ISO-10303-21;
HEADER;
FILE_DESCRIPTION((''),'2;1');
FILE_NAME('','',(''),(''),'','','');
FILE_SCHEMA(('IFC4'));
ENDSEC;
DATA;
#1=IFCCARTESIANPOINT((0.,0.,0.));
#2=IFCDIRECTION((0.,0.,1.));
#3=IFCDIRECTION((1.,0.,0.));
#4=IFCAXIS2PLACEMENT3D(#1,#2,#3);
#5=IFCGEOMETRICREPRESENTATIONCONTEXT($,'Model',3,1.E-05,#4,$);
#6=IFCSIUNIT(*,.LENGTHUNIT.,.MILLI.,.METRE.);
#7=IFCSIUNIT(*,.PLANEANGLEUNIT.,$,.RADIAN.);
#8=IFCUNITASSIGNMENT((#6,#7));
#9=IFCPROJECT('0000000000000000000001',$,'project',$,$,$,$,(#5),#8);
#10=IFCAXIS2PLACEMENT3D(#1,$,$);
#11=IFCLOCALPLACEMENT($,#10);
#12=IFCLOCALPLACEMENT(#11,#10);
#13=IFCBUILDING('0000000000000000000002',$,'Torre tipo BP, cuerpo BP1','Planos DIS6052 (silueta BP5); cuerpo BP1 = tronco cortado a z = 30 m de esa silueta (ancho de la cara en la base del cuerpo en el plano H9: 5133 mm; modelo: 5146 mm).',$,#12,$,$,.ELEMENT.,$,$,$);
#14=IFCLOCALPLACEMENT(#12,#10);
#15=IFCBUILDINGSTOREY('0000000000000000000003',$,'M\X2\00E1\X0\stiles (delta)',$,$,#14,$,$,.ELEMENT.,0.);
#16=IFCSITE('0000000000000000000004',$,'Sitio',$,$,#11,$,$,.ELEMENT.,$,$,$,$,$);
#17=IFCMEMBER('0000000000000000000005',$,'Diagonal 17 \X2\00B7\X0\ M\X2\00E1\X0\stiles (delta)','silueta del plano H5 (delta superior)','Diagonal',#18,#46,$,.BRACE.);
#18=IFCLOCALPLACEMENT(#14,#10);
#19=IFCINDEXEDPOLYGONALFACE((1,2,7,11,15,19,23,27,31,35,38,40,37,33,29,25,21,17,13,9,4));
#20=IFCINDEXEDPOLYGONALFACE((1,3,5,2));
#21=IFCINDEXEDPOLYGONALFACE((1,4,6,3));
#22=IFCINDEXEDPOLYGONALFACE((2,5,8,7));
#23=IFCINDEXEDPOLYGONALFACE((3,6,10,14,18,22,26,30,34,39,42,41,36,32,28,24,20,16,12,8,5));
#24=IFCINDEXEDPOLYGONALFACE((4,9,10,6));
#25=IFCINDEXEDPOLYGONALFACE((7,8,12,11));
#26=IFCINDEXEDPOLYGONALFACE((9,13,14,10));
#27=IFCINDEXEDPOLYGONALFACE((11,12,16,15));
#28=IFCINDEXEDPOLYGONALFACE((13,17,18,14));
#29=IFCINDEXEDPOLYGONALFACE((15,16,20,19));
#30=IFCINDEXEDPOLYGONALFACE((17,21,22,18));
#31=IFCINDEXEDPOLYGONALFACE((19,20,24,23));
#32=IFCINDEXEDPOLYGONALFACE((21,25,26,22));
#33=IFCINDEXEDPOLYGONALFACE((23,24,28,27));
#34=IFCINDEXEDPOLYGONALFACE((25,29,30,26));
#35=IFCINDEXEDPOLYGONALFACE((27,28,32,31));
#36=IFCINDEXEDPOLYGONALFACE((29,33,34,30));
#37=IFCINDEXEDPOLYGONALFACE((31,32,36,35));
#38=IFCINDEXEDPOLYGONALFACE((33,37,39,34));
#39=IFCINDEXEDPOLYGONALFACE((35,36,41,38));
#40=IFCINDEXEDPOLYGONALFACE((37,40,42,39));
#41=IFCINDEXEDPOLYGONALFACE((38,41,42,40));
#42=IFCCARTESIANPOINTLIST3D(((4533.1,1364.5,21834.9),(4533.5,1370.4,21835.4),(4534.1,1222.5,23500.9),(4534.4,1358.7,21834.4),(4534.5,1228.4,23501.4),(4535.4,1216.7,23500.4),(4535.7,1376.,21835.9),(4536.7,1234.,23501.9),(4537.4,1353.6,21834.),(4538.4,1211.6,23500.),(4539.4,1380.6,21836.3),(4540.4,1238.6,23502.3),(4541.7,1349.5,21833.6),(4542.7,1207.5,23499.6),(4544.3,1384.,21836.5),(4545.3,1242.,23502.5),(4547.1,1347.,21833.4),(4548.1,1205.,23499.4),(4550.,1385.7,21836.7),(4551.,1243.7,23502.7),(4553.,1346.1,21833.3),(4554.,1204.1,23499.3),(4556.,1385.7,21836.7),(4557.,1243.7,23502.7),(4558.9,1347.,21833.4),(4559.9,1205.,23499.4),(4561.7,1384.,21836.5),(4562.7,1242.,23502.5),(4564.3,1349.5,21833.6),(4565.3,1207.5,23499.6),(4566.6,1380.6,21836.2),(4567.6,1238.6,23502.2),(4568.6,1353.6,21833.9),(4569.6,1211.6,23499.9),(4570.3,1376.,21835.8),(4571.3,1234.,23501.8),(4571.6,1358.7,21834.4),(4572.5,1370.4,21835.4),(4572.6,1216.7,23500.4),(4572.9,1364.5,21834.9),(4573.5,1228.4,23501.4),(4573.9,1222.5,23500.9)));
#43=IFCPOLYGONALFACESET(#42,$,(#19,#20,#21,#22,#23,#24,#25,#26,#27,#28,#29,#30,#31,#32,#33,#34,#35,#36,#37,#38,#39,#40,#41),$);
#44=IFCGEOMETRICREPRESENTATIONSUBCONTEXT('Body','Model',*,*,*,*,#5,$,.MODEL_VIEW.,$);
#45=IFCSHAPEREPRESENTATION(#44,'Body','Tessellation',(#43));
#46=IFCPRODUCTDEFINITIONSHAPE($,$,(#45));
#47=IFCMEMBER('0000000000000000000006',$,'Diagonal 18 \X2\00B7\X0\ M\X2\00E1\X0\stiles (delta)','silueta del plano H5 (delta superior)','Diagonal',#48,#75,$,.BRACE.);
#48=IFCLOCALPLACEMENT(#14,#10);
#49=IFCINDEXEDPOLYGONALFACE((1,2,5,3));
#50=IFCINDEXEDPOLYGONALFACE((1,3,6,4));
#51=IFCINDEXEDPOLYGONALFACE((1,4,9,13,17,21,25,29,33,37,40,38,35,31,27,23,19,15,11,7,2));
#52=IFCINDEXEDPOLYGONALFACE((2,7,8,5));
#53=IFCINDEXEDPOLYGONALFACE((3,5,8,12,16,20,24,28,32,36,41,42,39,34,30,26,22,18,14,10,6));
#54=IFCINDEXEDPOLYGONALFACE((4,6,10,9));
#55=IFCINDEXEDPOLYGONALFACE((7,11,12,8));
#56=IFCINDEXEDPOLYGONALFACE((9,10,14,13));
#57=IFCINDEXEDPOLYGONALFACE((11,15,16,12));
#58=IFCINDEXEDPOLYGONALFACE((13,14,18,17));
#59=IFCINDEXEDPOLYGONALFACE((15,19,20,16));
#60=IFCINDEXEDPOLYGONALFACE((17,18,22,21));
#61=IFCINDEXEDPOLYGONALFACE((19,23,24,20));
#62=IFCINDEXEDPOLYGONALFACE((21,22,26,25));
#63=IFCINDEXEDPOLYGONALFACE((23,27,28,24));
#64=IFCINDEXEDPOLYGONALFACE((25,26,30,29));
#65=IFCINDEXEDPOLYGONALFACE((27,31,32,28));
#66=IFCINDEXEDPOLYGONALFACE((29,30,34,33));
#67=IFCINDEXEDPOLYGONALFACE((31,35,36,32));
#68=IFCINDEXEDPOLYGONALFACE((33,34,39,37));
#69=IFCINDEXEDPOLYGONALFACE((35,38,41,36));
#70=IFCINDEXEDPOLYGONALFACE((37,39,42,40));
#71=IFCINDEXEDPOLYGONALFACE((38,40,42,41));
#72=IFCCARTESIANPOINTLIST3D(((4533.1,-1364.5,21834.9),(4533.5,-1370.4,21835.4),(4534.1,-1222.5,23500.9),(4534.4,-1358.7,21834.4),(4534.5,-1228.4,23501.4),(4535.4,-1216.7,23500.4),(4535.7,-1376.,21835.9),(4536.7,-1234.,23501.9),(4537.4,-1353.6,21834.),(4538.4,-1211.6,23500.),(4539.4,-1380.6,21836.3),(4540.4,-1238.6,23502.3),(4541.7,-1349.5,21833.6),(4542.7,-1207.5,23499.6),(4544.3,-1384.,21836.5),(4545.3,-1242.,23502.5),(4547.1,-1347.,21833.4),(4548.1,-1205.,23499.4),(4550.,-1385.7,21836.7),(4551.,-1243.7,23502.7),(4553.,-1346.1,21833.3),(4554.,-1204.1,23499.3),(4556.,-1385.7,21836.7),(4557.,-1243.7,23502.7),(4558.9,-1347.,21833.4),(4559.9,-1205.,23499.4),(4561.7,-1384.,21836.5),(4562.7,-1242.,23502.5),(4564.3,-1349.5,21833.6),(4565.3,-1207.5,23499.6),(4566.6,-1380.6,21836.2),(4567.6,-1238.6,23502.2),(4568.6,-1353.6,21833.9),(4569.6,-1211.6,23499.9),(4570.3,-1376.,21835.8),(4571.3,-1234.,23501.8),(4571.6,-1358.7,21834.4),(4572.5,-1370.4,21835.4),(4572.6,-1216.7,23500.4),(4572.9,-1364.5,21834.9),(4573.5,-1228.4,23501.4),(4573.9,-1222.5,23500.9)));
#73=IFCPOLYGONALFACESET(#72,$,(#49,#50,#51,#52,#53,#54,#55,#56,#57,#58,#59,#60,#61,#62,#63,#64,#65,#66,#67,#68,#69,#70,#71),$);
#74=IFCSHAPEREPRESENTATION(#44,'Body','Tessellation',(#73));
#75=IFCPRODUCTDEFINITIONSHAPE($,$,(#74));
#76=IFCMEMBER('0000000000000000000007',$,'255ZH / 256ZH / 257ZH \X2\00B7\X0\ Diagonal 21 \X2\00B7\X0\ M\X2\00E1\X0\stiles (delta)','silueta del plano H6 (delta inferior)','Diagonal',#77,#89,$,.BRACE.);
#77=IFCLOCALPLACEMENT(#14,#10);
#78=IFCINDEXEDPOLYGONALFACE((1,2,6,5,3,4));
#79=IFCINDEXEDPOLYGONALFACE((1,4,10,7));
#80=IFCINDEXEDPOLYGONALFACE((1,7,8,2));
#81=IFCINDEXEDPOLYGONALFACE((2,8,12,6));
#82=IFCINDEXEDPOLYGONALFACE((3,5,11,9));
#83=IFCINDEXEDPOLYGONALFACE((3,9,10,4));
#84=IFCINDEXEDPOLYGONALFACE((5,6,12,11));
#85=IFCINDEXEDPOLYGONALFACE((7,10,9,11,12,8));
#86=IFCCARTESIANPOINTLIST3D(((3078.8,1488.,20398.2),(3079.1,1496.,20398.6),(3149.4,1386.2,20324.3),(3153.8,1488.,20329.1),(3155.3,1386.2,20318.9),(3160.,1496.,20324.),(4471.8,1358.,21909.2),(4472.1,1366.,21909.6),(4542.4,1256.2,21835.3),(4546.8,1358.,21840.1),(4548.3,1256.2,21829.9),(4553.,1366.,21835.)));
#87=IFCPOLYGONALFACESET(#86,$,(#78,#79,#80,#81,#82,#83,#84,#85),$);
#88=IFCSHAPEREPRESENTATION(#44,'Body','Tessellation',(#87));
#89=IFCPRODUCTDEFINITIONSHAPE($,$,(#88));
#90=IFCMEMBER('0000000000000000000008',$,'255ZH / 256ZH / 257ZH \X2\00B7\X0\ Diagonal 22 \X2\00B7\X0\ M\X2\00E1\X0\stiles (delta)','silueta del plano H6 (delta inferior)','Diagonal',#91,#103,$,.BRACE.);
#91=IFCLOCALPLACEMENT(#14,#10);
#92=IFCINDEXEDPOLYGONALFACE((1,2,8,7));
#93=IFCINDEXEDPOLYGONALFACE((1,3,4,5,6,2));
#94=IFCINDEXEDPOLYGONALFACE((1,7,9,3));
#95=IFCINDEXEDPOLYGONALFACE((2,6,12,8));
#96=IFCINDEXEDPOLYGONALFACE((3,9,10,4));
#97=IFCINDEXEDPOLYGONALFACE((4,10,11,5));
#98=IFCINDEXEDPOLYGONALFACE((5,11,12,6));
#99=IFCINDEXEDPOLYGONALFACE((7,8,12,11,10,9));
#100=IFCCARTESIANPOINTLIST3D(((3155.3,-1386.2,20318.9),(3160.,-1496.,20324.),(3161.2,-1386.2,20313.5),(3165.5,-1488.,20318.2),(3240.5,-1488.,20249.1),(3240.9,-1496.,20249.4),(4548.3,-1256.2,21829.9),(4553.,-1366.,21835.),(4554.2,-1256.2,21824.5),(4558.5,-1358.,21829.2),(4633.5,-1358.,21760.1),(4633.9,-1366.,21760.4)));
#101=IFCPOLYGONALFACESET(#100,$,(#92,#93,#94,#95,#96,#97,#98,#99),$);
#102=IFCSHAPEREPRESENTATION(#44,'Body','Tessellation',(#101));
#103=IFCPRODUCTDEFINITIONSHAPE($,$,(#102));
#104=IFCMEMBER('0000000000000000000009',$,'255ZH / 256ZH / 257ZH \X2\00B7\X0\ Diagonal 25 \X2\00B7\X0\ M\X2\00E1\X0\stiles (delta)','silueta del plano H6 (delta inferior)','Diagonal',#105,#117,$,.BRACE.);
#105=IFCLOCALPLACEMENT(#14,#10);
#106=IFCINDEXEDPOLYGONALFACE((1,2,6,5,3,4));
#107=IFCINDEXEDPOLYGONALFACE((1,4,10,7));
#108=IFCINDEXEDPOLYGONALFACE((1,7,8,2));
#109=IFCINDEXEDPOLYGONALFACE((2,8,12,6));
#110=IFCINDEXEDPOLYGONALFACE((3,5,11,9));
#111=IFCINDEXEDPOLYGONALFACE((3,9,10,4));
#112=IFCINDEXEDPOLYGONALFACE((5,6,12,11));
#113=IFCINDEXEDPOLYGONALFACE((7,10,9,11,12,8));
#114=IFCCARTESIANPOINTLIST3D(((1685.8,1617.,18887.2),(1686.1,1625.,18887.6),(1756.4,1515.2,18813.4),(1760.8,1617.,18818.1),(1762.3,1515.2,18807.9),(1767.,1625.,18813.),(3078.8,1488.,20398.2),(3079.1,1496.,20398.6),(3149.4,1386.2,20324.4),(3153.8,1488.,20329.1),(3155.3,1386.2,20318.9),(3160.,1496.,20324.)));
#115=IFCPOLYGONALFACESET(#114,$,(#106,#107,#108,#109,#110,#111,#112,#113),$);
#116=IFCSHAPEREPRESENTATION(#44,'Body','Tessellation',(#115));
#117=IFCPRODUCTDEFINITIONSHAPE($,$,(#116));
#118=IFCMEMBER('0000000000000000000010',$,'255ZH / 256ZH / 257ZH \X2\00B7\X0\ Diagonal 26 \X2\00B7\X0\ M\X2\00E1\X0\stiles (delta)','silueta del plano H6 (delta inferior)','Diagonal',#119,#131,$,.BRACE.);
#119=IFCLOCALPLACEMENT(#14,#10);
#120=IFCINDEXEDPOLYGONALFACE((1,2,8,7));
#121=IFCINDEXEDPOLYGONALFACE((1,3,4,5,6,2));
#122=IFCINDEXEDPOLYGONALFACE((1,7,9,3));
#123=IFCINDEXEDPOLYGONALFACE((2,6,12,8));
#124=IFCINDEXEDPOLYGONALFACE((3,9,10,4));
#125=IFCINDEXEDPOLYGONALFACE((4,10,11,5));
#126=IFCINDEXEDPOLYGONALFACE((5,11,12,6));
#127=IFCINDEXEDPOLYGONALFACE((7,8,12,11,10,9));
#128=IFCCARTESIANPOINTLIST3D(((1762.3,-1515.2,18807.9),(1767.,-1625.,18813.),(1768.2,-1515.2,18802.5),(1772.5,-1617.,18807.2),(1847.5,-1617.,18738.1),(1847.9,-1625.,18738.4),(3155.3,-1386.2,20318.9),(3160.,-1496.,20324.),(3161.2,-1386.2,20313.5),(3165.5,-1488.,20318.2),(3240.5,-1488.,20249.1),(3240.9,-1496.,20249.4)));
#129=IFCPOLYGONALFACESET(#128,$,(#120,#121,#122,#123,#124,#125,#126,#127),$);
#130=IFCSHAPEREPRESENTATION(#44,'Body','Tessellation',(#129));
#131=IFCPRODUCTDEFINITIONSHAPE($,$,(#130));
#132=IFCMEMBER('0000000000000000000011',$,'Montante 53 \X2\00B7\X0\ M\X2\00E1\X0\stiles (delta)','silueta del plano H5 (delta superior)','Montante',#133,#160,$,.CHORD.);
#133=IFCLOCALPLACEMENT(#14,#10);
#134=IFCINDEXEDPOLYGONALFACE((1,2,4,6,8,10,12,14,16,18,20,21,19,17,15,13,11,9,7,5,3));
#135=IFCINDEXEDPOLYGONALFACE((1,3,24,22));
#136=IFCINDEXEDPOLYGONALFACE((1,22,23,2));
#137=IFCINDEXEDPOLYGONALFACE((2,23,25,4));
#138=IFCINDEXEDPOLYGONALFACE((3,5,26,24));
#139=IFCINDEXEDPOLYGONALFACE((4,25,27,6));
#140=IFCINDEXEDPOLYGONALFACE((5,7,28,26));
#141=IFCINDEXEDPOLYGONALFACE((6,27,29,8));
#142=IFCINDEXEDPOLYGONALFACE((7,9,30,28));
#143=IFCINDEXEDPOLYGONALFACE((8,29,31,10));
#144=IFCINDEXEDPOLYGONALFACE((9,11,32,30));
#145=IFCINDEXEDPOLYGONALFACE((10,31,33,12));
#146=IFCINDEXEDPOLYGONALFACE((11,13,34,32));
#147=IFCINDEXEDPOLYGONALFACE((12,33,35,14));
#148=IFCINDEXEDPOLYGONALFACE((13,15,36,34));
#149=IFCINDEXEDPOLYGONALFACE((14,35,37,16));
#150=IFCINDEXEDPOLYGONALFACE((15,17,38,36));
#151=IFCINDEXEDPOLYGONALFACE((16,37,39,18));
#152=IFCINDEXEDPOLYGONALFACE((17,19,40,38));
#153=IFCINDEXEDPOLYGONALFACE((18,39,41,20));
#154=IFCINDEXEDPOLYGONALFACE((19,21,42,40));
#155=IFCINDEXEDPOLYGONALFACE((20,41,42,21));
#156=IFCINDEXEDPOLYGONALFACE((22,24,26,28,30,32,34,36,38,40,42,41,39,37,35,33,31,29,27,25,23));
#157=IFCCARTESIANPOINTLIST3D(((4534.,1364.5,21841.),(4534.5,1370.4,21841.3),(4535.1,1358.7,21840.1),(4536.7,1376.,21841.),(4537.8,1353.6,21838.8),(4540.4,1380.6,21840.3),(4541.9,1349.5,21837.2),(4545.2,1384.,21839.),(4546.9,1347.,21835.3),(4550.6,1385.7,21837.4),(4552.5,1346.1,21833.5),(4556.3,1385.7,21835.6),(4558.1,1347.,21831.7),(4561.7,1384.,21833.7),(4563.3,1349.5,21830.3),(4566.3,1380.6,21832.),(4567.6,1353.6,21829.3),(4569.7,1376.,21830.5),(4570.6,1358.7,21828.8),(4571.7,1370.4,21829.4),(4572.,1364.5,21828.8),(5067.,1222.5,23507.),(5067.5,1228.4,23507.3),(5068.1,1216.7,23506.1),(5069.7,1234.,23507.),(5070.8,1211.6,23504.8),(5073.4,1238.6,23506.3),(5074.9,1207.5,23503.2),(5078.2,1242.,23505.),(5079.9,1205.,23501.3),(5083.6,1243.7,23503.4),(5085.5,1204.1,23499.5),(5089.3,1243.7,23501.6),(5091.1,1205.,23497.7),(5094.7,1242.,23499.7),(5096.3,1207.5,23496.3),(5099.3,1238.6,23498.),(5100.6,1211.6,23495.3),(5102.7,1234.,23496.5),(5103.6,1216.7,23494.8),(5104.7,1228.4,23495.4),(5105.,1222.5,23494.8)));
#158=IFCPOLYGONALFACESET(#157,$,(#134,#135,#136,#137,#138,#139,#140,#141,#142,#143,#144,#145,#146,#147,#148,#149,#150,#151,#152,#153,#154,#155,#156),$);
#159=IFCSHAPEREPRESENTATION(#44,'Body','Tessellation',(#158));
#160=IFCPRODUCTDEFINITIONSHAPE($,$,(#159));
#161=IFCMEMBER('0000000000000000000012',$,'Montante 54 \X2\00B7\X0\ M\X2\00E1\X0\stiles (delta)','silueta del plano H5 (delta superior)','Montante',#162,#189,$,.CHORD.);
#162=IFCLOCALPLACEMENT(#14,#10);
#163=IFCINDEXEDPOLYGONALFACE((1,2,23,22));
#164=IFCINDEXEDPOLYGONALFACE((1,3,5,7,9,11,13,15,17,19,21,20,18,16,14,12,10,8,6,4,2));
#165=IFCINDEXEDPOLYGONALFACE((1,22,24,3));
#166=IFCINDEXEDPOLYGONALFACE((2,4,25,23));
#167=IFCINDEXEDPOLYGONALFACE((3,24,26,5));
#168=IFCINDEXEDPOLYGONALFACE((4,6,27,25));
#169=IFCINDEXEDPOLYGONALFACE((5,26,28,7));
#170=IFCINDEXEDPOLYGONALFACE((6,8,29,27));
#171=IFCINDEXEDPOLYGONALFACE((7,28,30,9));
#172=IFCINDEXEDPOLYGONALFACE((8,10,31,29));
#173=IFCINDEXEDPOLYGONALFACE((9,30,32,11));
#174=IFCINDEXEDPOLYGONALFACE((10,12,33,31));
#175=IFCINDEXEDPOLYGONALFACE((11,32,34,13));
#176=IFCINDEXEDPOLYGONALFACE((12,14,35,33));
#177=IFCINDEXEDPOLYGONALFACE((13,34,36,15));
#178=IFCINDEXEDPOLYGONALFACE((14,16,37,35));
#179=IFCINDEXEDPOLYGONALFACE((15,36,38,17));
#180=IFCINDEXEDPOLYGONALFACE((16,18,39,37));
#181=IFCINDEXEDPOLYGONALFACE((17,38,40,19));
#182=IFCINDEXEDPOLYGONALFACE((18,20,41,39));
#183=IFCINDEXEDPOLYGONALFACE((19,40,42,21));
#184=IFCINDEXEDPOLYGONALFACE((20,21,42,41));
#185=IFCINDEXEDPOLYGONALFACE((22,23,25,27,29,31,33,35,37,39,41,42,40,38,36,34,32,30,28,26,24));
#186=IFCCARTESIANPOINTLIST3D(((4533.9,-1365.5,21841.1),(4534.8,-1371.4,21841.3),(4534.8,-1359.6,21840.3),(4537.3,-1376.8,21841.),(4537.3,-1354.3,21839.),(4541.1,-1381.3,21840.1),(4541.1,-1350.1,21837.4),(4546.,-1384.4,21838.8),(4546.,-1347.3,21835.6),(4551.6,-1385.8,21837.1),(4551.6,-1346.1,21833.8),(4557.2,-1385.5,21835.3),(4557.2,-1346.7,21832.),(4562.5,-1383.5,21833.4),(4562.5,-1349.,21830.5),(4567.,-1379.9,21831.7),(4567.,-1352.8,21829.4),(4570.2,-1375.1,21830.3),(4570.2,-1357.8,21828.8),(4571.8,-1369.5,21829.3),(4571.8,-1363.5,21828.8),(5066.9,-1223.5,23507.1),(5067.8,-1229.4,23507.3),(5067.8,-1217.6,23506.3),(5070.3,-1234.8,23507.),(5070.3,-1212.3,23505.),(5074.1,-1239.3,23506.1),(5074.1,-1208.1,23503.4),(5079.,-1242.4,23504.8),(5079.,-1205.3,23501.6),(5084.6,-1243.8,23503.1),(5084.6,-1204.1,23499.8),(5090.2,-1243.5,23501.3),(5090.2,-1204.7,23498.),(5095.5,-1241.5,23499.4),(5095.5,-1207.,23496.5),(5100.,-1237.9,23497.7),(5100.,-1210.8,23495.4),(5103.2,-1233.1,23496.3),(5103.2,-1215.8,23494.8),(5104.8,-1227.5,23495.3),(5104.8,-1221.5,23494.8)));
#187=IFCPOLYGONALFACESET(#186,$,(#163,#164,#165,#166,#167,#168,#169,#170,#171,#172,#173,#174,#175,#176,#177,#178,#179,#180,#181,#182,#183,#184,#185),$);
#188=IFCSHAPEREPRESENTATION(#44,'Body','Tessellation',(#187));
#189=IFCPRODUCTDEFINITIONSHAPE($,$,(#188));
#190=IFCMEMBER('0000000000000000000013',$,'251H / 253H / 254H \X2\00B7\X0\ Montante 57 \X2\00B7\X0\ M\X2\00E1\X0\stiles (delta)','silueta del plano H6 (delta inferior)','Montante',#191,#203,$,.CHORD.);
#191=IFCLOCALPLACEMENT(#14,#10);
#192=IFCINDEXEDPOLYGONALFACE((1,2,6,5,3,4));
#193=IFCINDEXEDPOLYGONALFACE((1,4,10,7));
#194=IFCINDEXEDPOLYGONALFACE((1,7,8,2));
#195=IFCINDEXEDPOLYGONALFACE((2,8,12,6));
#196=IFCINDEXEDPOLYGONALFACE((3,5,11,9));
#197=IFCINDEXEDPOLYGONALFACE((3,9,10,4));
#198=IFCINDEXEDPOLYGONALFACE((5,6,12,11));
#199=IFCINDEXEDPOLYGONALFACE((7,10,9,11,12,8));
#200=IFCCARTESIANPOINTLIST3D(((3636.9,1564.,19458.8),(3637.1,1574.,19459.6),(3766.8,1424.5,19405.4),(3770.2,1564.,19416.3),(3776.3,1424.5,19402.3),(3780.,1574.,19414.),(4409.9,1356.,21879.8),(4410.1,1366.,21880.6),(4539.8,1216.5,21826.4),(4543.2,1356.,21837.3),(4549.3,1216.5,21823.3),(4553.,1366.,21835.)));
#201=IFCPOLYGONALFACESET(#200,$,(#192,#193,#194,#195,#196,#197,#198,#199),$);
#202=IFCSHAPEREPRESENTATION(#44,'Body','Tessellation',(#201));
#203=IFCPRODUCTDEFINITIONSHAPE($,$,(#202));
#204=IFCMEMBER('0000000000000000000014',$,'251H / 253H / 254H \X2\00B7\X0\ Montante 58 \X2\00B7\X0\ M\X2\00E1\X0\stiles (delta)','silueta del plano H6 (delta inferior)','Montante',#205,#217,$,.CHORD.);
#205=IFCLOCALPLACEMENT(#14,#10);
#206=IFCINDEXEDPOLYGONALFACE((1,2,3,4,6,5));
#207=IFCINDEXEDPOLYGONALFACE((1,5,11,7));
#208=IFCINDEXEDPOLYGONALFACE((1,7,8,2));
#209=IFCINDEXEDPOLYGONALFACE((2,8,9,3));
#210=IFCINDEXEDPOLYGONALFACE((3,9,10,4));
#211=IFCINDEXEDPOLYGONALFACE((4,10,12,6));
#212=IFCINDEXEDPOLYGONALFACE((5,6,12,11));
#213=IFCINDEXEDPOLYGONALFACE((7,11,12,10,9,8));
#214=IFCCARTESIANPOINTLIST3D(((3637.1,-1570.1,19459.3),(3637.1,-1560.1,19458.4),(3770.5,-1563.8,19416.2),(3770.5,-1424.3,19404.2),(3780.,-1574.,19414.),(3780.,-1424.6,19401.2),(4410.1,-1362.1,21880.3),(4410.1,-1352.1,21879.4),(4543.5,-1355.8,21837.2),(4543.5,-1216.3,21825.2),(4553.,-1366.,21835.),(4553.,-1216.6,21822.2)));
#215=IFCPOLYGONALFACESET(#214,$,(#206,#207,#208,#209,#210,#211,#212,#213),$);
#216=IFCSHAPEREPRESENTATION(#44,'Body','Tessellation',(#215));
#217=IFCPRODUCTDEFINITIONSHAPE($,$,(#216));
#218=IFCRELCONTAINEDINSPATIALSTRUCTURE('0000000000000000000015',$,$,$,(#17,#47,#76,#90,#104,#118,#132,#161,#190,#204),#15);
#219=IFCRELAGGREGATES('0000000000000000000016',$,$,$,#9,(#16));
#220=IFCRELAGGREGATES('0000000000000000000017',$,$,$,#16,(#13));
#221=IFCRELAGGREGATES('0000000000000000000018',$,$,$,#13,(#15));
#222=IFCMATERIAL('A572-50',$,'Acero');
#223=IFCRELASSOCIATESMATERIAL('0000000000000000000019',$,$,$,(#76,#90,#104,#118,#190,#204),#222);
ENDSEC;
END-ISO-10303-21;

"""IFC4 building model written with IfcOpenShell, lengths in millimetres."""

from ifc_helpers import new_model, si_unit, frame, frame_2d, origin, origin_with_axes, place, context, subcontext, project, spatial, circle, l_section, extrude, material, element, save


model = new_model("IFC4")

# Units and contexts
model_context = context("Model", 3, precision=1e-05, world=origin_with_axes())
body_context = subcontext(model_context, "Body", "Model", "MODEL_VIEW")
ifc_project = project(units=[si_unit("LENGTHUNIT", "METRE", prefix="MILLI"), si_unit("PLANEANGLEUNIT", "RADIAN")], contexts=[model_context])

# Site, building, storey
site_placement = place(None, origin())
site = spatial("IfcSite", under=ifc_project, at=site_placement, Name="Sitio", CompositionType="ELEMENT")
building_placement = place(site_placement, origin())
building = spatial("IfcBuilding", under=site, at=building_placement, Name="Torre tipo BP, cuerpo BP1", Description="Planos DIS6052 (silueta BP5); cuerpo BP1 = tronco cortado a z = 30 m de esa silueta (ancho de la cara en la base del cuerpo en el plano H9: 5133 mm; modelo: 5146 mm).", CompositionType="ELEMENT")
storey_placement = place(building_placement, origin())
storey = spatial("IfcBuildingStorey", under=building, at=storey_placement, Name="Mástiles (delta)", CompositionType="ELEMENT", Elevation=0.0)

# Members
for number, where, z_axis, x_axis, name in (
    (1, (4554.0, 1224.0, 23501.0), (-0.000598, 0.084926, -0.996387), (-0.000051, -0.996387, -0.084926), "Diagonal 17 · Mástiles (delta)"),
    (2, (4554.0, -1224.0, 23501.0), (-0.000598, -0.084926, -0.996387), (-0.000051, 0.996387, -0.084926), "Diagonal 18 · Mástiles (delta)"),
):
    element("IfcMember", number, at=place(storey_placement, frame(where, z_axis=z_axis, x_axis=x_axis)), inside=storey, Name=name, Description="silueta del plano H5 (delta superior)", ObjectType="Diagonal", PredefinedType="BRACE", context=body_context, shape_type="SweptSolid", body=[
        extrude(circle(Radius=20.0), None, (0.0, 0.0, 1.0), 1672.0),
    ])
ifc_material = material(Name="A572-50", Category="Acero")
for number, where, z_axis, x_axis, name in (
    (3, (4553.0, 1366.0, 21835.0), (-0.676463, 0.06313, -0.733766), (-0.042791, -0.998005, -0.046415), "255ZH / 256ZH / 257ZH · Diagonal 21 · Mástiles (delta)"),
    (4, (4553.0, -1366.0, 21835.0), (-0.676463, -0.06313, -0.733766), (-0.042791, 0.998005, -0.046415), "255ZH / 256ZH / 257ZH · Diagonal 22 · Mástiles (delta)"),
):
    element("IfcMember", number, at=place(storey_placement, frame(where, z_axis=z_axis, x_axis=x_axis)), inside=storey, material=ifc_material, Name=name, Description="silueta del plano H6 (delta inferior)", ObjectType="Diagonal", PredefinedType="BRACE", context=body_context, shape_type="SweptSolid", body=[
        extrude(l_section(Depth=110.0, Width=110.0, Thickness=8.0, at=frame_2d((55.0, 55.0))), None, (0.0, 0.0, 1.0), 2059.2),
    ])
for number, where, z_axis, x_axis, name in (
    (5, (3160.0, 1496.0, 20324.0), (-0.676484, 0.062646, -0.733788), (-0.042463, -0.998036, -0.04606), "255ZH / 256ZH / 257ZH · Diagonal 25 · Mástiles (delta)"),
    (6, (3160.0, -1496.0, 20324.0), (-0.676484, -0.062646, -0.733788), (-0.042463, 0.998036, -0.04606), "255ZH / 256ZH / 257ZH · Diagonal 26 · Mástiles (delta)"),
):
    element("IfcMember", number, at=place(storey_placement, frame(where, z_axis=z_axis, x_axis=x_axis)), inside=storey, material=ifc_material, Name=name, Description="silueta del plano H6 (delta inferior)", ObjectType="Diagonal", PredefinedType="BRACE", context=body_context, shape_type="SweptSolid", body=[
        extrude(l_section(Depth=110.0, Width=110.0, Thickness=8.0, at=frame_2d((55.0, 55.0))), None, (0.0, 0.0, 1.0), 2059.2),
    ])
for number, where, z_axis, x_axis, name in (
    (7, (5086.0, 1224.0, 23501.0), (-0.303714, 0.080915, -0.949321), (-0.024656, -0.996721, -0.077067), "Montante 53 · Mástiles (delta)"),
    (8, (5086.0, -1224.0, 23501.0), (-0.303714, -0.080915, -0.949321), (-0.952763, 0.025793, 0.302617), "Montante 54 · Mástiles (delta)"),
):
    element("IfcMember", number, at=place(storey_placement, frame(where, z_axis=z_axis, x_axis=x_axis)), inside=storey, Name=name, Description="silueta del plano H5 (delta superior)", ObjectType="Montante", PredefinedType="CHORD", context=body_context, shape_type="SweptSolid", body=[
        extrude(circle(Radius=20.0), None, (0.0, 0.0, 1.0), 1754.9),
    ])
for number, where, z_axis, x_axis, name in (
    (9, (4553.0, 1366.0, 21835.0), (-0.303148, 0.081572, -0.949446), (-0.024811, -0.996667, -0.077707), "251H / 253H / 254H · Montante 57 · Mástiles (delta)"),
    (10, (4553.0, -1366.0, 21835.0), (-0.303148, -0.081572, -0.949446), (-0.952943, 0.025949, 0.302035), "251H / 253H / 254H · Montante 58 · Mástiles (delta)"),
):
    element("IfcMember", number, at=place(storey_placement, frame(where, z_axis=z_axis, x_axis=x_axis)), inside=storey, material=ifc_material, Name=name, Description="silueta del plano H6 (delta inferior)", ObjectType="Montante", PredefinedType="CHORD", context=body_context, shape_type="SweptSolid", body=[
        extrude(l_section(Depth=150.0, Width=150.0, Thickness=10.0, at=frame_2d((75.0, 75.0))), None, (0.0, 0.0, 1.0), 2549.9),
    ])

save(model, "model.ifc")
